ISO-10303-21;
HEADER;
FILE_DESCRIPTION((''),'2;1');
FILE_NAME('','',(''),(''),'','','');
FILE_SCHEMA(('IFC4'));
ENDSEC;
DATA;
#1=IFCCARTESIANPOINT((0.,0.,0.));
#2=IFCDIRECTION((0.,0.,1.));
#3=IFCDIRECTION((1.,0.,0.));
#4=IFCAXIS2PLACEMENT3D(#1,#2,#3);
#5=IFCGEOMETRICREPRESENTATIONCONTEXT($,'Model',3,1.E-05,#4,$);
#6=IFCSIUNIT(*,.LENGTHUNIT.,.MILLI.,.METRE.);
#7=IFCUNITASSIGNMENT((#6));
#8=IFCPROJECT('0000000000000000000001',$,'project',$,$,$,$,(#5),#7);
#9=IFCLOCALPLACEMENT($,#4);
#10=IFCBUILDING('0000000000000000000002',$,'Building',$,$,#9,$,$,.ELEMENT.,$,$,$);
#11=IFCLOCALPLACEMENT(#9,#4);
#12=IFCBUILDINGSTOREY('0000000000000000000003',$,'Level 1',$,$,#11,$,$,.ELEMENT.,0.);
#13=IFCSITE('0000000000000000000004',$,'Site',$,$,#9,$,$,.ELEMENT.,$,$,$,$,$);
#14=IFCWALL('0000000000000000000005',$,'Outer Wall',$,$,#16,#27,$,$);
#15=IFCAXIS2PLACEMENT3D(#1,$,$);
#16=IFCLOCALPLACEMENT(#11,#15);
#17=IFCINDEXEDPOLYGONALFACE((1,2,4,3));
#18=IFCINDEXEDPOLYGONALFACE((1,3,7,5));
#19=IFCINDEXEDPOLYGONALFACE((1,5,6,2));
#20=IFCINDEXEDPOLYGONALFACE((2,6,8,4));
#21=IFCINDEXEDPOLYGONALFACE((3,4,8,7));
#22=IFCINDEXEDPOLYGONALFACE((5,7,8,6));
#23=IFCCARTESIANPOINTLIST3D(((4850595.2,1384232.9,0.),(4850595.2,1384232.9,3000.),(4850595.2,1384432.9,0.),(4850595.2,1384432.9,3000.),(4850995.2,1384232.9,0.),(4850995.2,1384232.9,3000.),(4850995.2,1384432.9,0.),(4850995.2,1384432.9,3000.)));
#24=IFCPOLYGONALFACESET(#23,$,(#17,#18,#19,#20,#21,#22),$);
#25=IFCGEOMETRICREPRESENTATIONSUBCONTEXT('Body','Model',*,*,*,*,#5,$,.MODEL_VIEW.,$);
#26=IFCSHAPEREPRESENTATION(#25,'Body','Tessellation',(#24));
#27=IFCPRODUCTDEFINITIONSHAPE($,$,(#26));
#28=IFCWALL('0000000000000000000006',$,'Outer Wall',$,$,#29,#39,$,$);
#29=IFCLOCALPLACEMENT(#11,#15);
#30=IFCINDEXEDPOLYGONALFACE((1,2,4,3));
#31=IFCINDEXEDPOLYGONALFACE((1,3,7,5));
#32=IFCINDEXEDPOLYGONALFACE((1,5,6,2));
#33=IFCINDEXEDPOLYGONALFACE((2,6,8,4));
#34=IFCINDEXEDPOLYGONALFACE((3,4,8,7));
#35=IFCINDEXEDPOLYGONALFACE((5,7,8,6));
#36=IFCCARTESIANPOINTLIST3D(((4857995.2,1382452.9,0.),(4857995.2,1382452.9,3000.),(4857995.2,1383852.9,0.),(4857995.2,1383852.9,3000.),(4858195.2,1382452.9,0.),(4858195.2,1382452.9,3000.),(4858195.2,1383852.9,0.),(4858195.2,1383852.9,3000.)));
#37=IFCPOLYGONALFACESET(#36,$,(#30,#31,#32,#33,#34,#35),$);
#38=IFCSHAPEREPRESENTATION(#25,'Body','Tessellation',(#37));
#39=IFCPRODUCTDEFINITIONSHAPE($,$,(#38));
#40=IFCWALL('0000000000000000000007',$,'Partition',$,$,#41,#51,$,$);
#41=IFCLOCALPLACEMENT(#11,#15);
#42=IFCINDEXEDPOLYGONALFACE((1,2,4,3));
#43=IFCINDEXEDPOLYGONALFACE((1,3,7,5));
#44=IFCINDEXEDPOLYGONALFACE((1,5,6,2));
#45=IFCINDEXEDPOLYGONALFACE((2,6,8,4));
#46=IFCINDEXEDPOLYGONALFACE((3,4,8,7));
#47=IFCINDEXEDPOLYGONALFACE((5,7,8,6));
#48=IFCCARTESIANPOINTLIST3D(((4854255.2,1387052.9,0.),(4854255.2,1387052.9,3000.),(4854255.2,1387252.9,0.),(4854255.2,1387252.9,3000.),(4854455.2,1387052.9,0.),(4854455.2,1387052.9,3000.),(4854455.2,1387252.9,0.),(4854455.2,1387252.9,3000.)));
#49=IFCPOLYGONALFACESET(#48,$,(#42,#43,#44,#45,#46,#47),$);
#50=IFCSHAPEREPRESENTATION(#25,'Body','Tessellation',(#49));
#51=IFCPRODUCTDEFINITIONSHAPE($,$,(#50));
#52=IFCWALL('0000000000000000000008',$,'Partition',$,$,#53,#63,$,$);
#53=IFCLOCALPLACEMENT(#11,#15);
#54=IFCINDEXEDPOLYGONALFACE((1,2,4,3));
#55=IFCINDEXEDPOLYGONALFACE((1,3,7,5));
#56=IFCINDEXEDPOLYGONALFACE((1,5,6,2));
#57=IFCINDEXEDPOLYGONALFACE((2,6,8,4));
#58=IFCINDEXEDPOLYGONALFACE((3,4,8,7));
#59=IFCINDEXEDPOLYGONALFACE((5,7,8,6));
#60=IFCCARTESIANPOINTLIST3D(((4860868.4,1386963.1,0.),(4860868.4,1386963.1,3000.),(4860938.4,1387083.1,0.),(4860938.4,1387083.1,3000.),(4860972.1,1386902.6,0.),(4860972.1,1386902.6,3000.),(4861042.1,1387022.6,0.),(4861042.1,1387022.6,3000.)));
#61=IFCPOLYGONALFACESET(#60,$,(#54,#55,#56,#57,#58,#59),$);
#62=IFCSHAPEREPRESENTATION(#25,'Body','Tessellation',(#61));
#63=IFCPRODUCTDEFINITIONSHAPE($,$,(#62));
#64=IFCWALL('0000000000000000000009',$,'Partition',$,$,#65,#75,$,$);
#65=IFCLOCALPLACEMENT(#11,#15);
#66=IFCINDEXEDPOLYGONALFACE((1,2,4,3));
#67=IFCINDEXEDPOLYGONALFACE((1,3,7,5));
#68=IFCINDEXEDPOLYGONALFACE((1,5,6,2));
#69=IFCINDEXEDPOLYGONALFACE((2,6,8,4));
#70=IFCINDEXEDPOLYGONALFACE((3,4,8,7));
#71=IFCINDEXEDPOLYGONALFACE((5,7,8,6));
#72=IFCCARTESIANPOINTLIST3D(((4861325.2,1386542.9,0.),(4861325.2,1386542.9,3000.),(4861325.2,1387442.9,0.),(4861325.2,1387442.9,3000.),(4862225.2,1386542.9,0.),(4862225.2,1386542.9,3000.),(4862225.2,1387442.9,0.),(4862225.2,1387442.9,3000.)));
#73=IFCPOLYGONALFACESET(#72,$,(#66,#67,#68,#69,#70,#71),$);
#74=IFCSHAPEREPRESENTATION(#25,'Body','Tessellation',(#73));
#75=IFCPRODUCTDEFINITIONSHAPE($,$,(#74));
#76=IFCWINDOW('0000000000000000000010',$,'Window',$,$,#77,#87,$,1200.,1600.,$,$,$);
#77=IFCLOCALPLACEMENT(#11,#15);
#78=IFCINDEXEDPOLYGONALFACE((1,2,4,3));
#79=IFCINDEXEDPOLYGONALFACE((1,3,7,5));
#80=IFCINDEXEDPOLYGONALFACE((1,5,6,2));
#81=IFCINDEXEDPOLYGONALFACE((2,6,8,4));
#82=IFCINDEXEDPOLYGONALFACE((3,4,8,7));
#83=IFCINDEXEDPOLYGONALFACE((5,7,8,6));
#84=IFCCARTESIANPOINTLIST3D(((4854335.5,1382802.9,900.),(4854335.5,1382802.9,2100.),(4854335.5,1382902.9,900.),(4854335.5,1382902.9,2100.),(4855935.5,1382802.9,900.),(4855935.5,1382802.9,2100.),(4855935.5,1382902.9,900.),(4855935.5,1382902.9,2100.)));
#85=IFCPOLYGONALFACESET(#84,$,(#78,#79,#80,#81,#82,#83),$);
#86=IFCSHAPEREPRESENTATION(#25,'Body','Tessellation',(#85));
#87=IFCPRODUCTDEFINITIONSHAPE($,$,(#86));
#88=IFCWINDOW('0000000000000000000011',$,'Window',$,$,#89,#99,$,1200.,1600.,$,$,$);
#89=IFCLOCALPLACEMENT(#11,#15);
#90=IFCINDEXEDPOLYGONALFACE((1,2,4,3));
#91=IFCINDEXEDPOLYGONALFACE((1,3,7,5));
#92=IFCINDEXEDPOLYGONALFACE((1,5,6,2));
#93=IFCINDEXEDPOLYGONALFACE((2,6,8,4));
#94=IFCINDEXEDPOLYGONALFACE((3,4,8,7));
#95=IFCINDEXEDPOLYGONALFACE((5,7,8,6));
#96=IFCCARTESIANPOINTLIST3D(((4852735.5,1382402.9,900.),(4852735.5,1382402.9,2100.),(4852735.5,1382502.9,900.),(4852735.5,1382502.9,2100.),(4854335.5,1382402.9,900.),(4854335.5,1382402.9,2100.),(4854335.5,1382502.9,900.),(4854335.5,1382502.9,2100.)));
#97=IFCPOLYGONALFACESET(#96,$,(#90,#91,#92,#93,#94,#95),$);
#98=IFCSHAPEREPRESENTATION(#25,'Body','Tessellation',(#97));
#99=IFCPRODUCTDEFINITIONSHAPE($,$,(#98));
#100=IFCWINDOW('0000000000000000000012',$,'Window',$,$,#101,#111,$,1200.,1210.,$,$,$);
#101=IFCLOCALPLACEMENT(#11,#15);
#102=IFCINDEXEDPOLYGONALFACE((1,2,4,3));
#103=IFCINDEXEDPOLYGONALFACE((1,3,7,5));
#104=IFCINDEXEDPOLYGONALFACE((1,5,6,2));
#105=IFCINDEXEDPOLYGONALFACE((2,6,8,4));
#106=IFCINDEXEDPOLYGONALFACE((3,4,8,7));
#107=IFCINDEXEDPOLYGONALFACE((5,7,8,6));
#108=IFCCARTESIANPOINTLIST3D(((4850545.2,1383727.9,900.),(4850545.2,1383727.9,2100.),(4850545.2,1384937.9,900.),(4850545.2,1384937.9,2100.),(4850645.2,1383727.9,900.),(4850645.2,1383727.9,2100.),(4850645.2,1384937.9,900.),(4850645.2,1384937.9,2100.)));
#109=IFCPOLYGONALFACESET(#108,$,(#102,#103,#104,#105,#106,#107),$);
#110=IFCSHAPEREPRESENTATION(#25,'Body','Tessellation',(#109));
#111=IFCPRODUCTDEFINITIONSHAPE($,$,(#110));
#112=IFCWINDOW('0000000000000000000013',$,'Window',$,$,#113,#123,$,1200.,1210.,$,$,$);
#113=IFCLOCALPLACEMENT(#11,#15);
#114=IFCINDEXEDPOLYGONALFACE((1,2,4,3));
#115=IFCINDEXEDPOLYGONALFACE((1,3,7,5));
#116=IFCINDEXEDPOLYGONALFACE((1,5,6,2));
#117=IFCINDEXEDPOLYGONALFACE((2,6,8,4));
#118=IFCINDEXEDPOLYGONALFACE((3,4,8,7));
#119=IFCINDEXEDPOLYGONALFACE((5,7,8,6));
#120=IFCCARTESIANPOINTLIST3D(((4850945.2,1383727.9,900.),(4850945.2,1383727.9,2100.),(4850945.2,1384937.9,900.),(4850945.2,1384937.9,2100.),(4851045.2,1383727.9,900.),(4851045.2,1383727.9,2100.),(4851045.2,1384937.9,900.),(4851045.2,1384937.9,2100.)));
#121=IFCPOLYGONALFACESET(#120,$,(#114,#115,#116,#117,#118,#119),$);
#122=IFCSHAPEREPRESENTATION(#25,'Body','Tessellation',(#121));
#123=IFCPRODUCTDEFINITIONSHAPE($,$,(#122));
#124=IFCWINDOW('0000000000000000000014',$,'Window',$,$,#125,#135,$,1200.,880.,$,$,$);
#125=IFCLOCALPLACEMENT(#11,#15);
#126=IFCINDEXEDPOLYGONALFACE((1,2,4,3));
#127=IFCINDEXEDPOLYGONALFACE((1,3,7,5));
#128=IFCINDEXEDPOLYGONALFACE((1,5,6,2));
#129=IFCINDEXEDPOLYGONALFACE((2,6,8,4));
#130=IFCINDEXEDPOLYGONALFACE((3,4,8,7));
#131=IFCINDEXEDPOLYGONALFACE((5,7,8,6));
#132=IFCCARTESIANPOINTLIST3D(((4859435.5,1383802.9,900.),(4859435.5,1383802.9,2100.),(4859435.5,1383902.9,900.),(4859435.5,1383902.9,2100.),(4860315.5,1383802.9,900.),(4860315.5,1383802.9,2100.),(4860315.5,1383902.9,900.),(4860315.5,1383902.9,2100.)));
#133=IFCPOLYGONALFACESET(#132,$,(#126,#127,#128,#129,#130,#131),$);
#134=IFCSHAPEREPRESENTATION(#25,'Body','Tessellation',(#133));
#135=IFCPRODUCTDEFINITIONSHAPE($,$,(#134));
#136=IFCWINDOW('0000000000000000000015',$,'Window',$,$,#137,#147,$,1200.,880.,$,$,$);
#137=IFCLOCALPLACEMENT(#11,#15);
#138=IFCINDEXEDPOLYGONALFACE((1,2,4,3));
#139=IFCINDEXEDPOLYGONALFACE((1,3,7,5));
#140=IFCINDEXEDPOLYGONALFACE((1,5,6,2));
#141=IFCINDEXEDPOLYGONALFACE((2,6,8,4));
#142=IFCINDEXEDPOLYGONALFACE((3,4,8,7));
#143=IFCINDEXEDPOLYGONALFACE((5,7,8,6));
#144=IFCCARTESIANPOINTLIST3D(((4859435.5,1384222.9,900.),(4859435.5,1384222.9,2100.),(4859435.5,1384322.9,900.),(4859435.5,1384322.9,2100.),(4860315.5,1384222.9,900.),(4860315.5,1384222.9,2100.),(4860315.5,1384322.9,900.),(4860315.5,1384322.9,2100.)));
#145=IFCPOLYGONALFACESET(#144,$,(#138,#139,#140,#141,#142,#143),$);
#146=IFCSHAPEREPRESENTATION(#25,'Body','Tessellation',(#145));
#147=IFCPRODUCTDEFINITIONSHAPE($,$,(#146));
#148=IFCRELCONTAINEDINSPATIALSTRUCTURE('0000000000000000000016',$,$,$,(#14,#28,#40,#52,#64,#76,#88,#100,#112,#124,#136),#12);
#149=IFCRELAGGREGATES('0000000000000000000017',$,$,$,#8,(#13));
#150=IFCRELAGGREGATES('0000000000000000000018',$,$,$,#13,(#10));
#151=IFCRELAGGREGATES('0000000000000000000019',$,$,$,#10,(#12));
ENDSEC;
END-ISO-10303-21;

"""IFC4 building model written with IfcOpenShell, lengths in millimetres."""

from ifc_helpers import new_model, si_unit, frame, frame_2d, origin_with_axes, place, context, subcontext, project, spatial, rectangle, extrude, element, save


model = new_model("IFC4")

# Units and contexts
model_context = context("Model", 3, precision=1e-05, world=origin_with_axes())
body_context = subcontext(model_context, "Body", "Model", "MODEL_VIEW")
ifc_project = project(units=[si_unit("LENGTHUNIT", "METRE", prefix="MILLI")], contexts=[model_context])

# Site, building, storey
placement = place(None, origin_with_axes())
site = spatial("IfcSite", under=ifc_project, at=placement, Name="Site", CompositionType="ELEMENT")
building = spatial("IfcBuilding", under=site, at=placement, Name="Building", CompositionType="ELEMENT")
storey_placement = place(placement, origin_with_axes())
storey = spatial("IfcBuildingStorey", under=building, at=storey_placement, Name="Level 1", CompositionType="ELEMENT", Elevation=0.0)

# Walls
wall_1_placement = place(placement, frame((4850995.2, 1384332.9, 0.0), z_axis=(0.0, 0.0, 1.0), x_axis=(-1.0, 0.0, 0.0)))
element("IfcWall", 1, at=wall_1_placement, inside=storey, Name="Outer Wall", context=body_context, shape_type="SweptSolid", body=[
    extrude(rectangle(XDim=400.0, YDim=200.0, at=frame_2d((200.0, 0.0), x_axis=(1.0, 0.0))), origin_with_axes(), (0.0, 0.0, 1.0), 3000.0),
])
wall_2_placement = place(placement, frame((4858095.2, 1383852.9, 0.0), z_axis=(0.0, 0.0, 1.0), x_axis=(0.0, -1.0, 0.0)))
element("IfcWall", 2, at=wall_2_placement, inside=storey, Name="Outer Wall", context=body_context, shape_type="SweptSolid", body=[
    extrude(rectangle(XDim=1400.0, YDim=200.0, at=frame_2d((700.0, 0.0), x_axis=(1.0, 0.0))), origin_with_axes(), (0.0, 0.0, 1.0), 3000.0),
])
wall_3_placement = place(placement, frame((4854355.2, 1387052.9, 0.0), z_axis=(0.0, 0.0, 1.0), x_axis=(0.0, 1.0, 0.0)))
element("IfcWall", 3, at=wall_3_placement, inside=storey, Name="Partition", context=body_context, shape_type="SweptSolid", body=[
    extrude(rectangle(XDim=200.0, YDim=200.0, at=frame_2d((100.0, 0.0), x_axis=(1.0, 0.0))), origin_with_axes(), (0.0, 0.0, 1.0), 3000.0),
])
wall_4_placement = place(placement, frame((4860990.2, 1387052.9, 0.0), z_axis=(0.0, 0.0, 1.0), x_axis=(-0.503871, -0.863779, 0.0)))
element("IfcWall", 4, at=wall_4_placement, inside=storey, Name="Partition", context=body_context, shape_type="SweptSolid", body=[
    extrude(rectangle(XDim=138.9, YDim=120.0, at=frame_2d((69.5, 0.0), x_axis=(1.0, 0.0))), origin_with_axes(), (0.0, 0.0, 1.0), 3000.0),
])
wall_5_placement = place(placement, frame((4861325.2, 1386992.9, 0.0), z_axis=(0.0, 0.0, 1.0), x_axis=(1.0, 0.0, 0.0)))
element("IfcWall", 5, at=wall_5_placement, inside=storey, Name="Partition", context=body_context, shape_type="SweptSolid", body=[
    extrude(rectangle(XDim=900.0, YDim=900.0, at=frame_2d((450.0, 0.0), x_axis=(1.0, 0.0))), origin_with_axes(), (0.0, 0.0, 1.0), 3000.0),
])

# Windows
for number, where, z_axis, x_axis, name in (
    (6, (4854335.5, 1382852.9, 900.0), (0.0, 0.0, 1.0), (1.0, 0.0, 0.0), "Window"),
    (7, (4854335.5, 1382452.9, 900.0), (0.0, 0.0, 1.0), (-1.0, 0.0, 0.0), "Window"),
):
    element("IfcWindow", number, at=place(placement, frame(where, z_axis=z_axis, x_axis=x_axis)), inside=storey, Name=name, OverallHeight=1200.0, OverallWidth=1600.0, context=body_context, shape_type="SweptSolid", body=[
        extrude(rectangle(XDim=1600.0, YDim=100.0, at=frame_2d((800.0, 0.0), x_axis=(1.0, 0.0))), origin_with_axes(), (0.0, 0.0, 1.0), 1200.0),
    ])
window_1_placement = place(placement, frame((4850595.2, 1384937.9, 900.0), z_axis=(0.0, 0.0, 1.0), x_axis=(0.0, -1.0, 0.0)))
element("IfcWindow", 8, at=window_1_placement, inside=storey, Name="Window", OverallHeight=1200.0, OverallWidth=1210.0, context=body_context, shape_type="SweptSolid", body=[
    extrude(rectangle(XDim=1210.0, YDim=100.0, at=frame_2d((605.0, 0.0), x_axis=(1.0, 0.0))), origin_with_axes(), (0.0, 0.0, 1.0), 1200.0),
])
window_2_placement = place(placement, frame((4850995.2, 1384937.9, 900.0), z_axis=(0.0, 0.0, 1.0), x_axis=(0.0, -1.0, 0.0)))
element("IfcWindow", 9, at=window_2_placement, inside=storey, Name="Window", OverallHeight=1200.0, OverallWidth=1210.0, context=body_context, shape_type="SweptSolid", body=[
    extrude(rectangle(XDim=1210.0, YDim=100.0, at=frame_2d((605.0, 0.0), x_axis=(1.0, 0.0))), origin_with_axes(), (0.0, 0.0, 1.0), 1200.0),
])
for number, where, z_axis, x_axis, name in (
    (10, (4859435.5, 1383852.9, 900.0), (0.0, 0.0, 1.0), (1.0, 0.0, 0.0), "Window"),
    (11, (4859435.5, 1384272.9, 900.0), (0.0, 0.0, 1.0), (1.0, 0.0, 0.0), "Window"),
):
    element("IfcWindow", number, at=place(placement, frame(where, z_axis=z_axis, x_axis=x_axis)), inside=storey, Name=name, OverallHeight=1200.0, OverallWidth=880.0, context=body_context, shape_type="SweptSolid", body=[
        extrude(rectangle(XDim=880.0, YDim=100.0, at=frame_2d((440.0, 0.0), x_axis=(1.0, 0.0))), origin_with_axes(), (0.0, 0.0, 1.0), 1200.0),
    ])

save(model, "model.ifc")
